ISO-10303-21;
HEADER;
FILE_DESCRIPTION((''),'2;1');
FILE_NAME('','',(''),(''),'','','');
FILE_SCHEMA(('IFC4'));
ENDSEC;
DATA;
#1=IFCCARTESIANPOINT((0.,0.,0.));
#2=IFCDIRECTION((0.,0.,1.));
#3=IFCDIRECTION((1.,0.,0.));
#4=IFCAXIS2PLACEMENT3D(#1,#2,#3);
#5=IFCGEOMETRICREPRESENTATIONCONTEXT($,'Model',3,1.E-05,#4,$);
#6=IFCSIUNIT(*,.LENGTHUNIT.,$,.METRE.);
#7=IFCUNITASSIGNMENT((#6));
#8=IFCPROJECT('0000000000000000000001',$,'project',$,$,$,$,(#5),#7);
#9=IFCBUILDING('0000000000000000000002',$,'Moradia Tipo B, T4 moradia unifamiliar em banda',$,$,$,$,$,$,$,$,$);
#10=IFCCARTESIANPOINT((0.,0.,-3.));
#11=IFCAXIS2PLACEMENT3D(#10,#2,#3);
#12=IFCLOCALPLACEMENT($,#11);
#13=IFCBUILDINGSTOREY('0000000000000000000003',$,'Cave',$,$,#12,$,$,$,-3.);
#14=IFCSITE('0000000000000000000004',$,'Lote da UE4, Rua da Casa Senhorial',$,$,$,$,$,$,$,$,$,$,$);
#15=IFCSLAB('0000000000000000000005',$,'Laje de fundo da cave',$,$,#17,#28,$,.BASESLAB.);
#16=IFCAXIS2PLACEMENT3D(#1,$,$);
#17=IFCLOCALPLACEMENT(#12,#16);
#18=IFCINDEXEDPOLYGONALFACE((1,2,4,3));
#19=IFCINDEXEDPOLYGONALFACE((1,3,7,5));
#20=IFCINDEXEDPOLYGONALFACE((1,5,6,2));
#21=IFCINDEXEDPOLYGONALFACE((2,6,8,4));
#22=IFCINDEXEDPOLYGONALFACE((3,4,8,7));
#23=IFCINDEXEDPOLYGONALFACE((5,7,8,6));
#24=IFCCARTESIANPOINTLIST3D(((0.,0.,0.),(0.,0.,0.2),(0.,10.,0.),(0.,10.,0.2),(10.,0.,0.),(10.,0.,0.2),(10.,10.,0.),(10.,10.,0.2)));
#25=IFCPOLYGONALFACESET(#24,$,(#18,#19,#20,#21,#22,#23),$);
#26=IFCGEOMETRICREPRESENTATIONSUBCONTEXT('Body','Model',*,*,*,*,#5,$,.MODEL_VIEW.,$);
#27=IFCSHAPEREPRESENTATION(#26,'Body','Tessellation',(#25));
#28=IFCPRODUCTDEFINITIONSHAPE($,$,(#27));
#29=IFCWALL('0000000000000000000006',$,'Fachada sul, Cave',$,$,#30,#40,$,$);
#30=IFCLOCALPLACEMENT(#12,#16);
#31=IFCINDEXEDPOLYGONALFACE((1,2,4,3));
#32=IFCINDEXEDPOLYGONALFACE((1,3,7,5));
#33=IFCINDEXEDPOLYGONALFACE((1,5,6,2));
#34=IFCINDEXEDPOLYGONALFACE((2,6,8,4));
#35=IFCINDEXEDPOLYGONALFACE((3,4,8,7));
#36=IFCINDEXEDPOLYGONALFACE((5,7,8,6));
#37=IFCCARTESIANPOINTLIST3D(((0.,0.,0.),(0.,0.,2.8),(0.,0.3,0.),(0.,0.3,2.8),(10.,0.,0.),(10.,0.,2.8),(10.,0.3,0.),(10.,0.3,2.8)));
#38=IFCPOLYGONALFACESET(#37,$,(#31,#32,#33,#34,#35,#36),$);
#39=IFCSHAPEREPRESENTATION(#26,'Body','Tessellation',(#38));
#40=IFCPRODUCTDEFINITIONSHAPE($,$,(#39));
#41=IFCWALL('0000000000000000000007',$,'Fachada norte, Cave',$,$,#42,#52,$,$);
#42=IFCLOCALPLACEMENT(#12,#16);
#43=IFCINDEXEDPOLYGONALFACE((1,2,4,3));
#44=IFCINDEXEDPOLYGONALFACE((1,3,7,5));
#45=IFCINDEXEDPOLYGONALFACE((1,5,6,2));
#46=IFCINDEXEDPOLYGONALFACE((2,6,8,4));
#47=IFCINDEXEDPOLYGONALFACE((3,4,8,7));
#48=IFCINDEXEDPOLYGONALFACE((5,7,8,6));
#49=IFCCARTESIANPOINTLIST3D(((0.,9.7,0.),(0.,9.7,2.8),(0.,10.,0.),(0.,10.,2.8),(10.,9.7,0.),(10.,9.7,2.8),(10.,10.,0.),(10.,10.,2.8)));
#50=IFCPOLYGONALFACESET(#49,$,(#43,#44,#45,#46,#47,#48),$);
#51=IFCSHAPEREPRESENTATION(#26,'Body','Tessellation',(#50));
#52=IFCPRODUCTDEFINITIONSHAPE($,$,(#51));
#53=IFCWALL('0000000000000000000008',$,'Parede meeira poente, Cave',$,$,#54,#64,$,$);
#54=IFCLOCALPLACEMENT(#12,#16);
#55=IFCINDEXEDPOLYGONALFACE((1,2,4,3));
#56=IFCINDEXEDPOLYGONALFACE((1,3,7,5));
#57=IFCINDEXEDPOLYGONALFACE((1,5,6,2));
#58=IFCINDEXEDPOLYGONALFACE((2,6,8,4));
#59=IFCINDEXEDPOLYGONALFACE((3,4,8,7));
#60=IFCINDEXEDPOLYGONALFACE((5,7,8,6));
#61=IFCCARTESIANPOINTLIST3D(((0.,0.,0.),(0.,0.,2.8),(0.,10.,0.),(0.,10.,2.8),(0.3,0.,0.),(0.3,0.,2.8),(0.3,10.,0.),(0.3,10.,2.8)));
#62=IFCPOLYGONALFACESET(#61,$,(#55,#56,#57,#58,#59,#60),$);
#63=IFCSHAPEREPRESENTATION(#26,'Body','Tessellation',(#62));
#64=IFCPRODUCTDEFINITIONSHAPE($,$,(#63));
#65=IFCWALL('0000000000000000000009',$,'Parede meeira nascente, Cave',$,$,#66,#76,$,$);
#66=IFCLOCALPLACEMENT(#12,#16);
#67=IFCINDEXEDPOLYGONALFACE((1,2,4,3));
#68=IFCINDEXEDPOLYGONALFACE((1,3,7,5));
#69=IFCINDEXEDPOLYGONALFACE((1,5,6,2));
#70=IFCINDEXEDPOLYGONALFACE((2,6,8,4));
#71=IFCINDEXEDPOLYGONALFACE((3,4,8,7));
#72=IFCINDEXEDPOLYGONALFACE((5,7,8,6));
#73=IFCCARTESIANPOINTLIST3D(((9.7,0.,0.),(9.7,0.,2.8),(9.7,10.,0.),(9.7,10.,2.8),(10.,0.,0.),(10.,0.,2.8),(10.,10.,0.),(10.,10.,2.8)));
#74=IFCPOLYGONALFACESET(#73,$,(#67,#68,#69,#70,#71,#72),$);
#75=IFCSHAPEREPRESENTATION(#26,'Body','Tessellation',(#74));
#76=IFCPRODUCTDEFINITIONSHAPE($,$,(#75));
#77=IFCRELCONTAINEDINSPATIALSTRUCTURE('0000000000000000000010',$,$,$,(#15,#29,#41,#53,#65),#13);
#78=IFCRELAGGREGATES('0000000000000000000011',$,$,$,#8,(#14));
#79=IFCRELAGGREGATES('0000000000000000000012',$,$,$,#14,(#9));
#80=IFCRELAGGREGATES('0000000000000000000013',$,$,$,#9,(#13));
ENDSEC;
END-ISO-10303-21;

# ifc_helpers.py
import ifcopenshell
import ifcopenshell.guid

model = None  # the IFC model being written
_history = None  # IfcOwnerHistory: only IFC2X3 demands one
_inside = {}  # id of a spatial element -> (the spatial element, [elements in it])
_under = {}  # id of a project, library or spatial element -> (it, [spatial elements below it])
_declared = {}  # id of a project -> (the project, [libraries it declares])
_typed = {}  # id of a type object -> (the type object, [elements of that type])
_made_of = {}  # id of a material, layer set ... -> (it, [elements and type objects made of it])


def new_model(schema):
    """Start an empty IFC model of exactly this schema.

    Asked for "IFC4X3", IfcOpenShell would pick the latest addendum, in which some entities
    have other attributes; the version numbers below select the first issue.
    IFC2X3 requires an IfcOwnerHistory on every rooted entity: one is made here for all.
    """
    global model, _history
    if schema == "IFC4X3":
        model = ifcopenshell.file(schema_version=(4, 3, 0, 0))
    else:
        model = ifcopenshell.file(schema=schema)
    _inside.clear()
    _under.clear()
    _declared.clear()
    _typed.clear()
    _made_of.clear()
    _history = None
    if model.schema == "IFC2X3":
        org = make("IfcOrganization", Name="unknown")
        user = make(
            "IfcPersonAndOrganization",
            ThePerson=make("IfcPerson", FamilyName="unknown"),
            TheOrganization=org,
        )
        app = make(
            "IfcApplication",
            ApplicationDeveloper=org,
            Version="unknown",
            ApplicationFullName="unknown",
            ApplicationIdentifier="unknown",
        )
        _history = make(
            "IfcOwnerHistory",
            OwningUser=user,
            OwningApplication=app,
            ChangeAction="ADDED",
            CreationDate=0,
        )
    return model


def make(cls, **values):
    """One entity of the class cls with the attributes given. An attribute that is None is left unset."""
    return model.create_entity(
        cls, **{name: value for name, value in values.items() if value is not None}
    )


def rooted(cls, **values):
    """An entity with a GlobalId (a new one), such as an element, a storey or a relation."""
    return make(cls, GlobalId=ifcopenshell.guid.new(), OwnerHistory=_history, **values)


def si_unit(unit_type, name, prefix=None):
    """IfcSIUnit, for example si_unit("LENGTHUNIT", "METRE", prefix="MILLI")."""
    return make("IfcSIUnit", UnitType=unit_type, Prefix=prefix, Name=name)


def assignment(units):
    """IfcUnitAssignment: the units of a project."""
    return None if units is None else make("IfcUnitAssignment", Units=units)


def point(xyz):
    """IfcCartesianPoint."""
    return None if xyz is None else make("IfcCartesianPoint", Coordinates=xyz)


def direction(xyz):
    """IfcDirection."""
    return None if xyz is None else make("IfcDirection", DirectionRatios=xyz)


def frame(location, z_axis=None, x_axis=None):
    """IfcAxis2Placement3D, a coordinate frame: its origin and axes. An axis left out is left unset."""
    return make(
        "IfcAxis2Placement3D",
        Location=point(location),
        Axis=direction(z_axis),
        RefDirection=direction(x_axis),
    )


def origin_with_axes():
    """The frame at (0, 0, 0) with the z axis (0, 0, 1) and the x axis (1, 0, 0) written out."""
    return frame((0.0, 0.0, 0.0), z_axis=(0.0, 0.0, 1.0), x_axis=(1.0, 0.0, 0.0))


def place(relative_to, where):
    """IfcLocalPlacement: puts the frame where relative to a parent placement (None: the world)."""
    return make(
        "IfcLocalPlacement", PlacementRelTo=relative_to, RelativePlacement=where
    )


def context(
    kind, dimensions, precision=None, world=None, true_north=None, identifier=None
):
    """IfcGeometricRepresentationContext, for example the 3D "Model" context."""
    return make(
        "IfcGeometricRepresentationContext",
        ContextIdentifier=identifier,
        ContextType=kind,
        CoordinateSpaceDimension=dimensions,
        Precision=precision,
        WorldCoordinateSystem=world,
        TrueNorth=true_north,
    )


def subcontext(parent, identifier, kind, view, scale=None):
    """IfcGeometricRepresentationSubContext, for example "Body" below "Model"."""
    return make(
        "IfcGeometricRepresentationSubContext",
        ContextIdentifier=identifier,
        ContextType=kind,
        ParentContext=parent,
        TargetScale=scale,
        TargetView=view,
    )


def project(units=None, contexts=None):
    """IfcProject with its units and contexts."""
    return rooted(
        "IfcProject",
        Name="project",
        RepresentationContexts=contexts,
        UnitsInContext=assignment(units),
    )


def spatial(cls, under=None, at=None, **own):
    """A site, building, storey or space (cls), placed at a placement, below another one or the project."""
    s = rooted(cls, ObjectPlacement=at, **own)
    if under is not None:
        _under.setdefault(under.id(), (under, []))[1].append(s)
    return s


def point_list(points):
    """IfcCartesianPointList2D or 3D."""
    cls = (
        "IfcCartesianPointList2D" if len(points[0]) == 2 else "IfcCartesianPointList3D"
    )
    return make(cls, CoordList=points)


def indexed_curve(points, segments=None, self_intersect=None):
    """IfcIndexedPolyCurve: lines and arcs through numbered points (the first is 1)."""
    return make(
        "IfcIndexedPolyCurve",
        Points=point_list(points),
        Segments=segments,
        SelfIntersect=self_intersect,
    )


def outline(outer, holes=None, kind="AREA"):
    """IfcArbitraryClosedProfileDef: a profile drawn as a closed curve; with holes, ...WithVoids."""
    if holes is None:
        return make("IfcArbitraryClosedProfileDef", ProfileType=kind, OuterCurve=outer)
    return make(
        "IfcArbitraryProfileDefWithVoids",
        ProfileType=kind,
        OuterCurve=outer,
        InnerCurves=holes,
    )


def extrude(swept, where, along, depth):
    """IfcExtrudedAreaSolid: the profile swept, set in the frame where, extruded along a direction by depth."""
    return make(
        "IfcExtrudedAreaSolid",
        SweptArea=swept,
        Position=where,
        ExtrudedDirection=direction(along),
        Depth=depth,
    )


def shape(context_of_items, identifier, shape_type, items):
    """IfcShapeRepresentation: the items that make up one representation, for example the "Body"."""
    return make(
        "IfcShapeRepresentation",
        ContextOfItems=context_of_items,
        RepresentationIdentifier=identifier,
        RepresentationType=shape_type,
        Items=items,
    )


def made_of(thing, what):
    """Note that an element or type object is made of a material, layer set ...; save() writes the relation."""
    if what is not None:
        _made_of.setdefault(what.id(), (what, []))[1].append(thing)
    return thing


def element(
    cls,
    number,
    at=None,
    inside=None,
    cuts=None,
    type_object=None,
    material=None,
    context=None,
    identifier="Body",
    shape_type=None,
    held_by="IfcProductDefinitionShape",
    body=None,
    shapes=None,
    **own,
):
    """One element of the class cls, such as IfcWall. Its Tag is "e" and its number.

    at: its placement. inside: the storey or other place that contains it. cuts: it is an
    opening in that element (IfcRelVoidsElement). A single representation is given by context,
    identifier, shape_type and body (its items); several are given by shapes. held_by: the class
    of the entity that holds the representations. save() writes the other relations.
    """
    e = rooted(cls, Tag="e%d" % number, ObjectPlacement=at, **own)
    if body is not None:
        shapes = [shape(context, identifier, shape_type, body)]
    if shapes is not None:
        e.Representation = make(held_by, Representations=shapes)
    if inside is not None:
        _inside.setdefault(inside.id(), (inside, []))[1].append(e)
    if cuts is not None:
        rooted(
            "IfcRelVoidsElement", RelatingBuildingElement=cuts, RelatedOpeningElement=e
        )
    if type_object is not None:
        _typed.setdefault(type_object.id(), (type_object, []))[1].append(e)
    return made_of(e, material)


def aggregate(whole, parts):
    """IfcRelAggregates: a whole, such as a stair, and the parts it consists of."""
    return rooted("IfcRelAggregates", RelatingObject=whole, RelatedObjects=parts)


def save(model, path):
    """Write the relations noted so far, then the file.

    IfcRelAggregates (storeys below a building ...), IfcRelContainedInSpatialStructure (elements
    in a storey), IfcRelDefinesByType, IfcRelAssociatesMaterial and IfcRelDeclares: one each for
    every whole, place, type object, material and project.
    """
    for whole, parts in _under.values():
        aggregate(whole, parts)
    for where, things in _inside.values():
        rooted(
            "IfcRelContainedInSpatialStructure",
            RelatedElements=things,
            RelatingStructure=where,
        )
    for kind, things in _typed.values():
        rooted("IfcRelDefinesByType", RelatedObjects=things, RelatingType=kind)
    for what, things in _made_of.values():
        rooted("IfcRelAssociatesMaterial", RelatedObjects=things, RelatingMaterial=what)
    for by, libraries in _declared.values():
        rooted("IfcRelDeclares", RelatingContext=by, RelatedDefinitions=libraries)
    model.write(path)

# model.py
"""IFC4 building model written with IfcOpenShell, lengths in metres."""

from ifc_helpers import new_model, si_unit, frame, origin_with_axes, place, context, subcontext, project, spatial, indexed_curve, outline, extrude, element, save


model = new_model("IFC4")

# Units and contexts
model_context = context("Model", 3, precision=1e-05, world=origin_with_axes())
body_context = subcontext(model_context, "Body", "Model", "MODEL_VIEW")
ifc_project = project(units=[si_unit("LENGTHUNIT", "METRE")], contexts=[model_context])

# Site, building, storey
site = spatial("IfcSite", under=ifc_project, Name="Lote da UE4, Rua da Casa Senhorial")
building = spatial("IfcBuilding", under=site, Name="Moradia Tipo B, T4 moradia unifamiliar em banda")
storey_placement = place(None, frame((0.0, 0.0, -3.0), z_axis=(0.0, 0.0, 1.0), x_axis=(1.0, 0.0, 0.0)))
storey = spatial("IfcBuildingStorey", under=building, at=storey_placement, Name="Cave", Elevation=-3.0)

# Slab
slab_placement = place(storey_placement, origin_with_axes())
element("IfcSlab", 1, at=slab_placement, inside=storey, Name="Laje de fundo da cave", PredefinedType="BASESLAB", context=body_context, shape_type="SweptSolid", body=[
    extrude(outline(indexed_curve([(0.0, 0.0), (10.0, 0.0), (10.0, 10.0), (0.0, 10.0), (0.0, 0.0)])), None, (0.0, 0.0, 1.0), 0.2),
])

# Walls
for number, where, z_axis, x_axis, name in (
    (2, (0.0, 0.0, 0.0), (0.0, 0.0, 1.0), (1.0, 0.0, 0.0), "Fachada sul, Cave"),
    (3, (0.0, 9.7, 0.0), (0.0, 0.0, 1.0), (1.0, 0.0, 0.0), "Fachada norte, Cave"),
    (4, (0.3, 0.0, 0.0), (0.0, 0.0, 1.0), (0.0, 1.0, 0.0), "Parede meeira poente, Cave"),
    (5, (10.0, 0.0, 0.0), (0.0, 0.0, 1.0), (0.0, 1.0, 0.0), "Parede meeira nascente, Cave"),
):
    element("IfcWall", number, at=place(storey_placement, frame(where, z_axis=z_axis, x_axis=x_axis)), inside=storey, Name=name, context=body_context, shape_type="SweptSolid", body=[
        extrude(outline(indexed_curve([(0.0, 0.0), (0.0, 0.3), (10.0, 0.3), (10.0, 0.0), (0.0, 0.0)], self_intersect=False)), origin_with_axes(), (0.0, 0.0, 1.0), 2.8),
    ])

save(model, "model.ifc")
